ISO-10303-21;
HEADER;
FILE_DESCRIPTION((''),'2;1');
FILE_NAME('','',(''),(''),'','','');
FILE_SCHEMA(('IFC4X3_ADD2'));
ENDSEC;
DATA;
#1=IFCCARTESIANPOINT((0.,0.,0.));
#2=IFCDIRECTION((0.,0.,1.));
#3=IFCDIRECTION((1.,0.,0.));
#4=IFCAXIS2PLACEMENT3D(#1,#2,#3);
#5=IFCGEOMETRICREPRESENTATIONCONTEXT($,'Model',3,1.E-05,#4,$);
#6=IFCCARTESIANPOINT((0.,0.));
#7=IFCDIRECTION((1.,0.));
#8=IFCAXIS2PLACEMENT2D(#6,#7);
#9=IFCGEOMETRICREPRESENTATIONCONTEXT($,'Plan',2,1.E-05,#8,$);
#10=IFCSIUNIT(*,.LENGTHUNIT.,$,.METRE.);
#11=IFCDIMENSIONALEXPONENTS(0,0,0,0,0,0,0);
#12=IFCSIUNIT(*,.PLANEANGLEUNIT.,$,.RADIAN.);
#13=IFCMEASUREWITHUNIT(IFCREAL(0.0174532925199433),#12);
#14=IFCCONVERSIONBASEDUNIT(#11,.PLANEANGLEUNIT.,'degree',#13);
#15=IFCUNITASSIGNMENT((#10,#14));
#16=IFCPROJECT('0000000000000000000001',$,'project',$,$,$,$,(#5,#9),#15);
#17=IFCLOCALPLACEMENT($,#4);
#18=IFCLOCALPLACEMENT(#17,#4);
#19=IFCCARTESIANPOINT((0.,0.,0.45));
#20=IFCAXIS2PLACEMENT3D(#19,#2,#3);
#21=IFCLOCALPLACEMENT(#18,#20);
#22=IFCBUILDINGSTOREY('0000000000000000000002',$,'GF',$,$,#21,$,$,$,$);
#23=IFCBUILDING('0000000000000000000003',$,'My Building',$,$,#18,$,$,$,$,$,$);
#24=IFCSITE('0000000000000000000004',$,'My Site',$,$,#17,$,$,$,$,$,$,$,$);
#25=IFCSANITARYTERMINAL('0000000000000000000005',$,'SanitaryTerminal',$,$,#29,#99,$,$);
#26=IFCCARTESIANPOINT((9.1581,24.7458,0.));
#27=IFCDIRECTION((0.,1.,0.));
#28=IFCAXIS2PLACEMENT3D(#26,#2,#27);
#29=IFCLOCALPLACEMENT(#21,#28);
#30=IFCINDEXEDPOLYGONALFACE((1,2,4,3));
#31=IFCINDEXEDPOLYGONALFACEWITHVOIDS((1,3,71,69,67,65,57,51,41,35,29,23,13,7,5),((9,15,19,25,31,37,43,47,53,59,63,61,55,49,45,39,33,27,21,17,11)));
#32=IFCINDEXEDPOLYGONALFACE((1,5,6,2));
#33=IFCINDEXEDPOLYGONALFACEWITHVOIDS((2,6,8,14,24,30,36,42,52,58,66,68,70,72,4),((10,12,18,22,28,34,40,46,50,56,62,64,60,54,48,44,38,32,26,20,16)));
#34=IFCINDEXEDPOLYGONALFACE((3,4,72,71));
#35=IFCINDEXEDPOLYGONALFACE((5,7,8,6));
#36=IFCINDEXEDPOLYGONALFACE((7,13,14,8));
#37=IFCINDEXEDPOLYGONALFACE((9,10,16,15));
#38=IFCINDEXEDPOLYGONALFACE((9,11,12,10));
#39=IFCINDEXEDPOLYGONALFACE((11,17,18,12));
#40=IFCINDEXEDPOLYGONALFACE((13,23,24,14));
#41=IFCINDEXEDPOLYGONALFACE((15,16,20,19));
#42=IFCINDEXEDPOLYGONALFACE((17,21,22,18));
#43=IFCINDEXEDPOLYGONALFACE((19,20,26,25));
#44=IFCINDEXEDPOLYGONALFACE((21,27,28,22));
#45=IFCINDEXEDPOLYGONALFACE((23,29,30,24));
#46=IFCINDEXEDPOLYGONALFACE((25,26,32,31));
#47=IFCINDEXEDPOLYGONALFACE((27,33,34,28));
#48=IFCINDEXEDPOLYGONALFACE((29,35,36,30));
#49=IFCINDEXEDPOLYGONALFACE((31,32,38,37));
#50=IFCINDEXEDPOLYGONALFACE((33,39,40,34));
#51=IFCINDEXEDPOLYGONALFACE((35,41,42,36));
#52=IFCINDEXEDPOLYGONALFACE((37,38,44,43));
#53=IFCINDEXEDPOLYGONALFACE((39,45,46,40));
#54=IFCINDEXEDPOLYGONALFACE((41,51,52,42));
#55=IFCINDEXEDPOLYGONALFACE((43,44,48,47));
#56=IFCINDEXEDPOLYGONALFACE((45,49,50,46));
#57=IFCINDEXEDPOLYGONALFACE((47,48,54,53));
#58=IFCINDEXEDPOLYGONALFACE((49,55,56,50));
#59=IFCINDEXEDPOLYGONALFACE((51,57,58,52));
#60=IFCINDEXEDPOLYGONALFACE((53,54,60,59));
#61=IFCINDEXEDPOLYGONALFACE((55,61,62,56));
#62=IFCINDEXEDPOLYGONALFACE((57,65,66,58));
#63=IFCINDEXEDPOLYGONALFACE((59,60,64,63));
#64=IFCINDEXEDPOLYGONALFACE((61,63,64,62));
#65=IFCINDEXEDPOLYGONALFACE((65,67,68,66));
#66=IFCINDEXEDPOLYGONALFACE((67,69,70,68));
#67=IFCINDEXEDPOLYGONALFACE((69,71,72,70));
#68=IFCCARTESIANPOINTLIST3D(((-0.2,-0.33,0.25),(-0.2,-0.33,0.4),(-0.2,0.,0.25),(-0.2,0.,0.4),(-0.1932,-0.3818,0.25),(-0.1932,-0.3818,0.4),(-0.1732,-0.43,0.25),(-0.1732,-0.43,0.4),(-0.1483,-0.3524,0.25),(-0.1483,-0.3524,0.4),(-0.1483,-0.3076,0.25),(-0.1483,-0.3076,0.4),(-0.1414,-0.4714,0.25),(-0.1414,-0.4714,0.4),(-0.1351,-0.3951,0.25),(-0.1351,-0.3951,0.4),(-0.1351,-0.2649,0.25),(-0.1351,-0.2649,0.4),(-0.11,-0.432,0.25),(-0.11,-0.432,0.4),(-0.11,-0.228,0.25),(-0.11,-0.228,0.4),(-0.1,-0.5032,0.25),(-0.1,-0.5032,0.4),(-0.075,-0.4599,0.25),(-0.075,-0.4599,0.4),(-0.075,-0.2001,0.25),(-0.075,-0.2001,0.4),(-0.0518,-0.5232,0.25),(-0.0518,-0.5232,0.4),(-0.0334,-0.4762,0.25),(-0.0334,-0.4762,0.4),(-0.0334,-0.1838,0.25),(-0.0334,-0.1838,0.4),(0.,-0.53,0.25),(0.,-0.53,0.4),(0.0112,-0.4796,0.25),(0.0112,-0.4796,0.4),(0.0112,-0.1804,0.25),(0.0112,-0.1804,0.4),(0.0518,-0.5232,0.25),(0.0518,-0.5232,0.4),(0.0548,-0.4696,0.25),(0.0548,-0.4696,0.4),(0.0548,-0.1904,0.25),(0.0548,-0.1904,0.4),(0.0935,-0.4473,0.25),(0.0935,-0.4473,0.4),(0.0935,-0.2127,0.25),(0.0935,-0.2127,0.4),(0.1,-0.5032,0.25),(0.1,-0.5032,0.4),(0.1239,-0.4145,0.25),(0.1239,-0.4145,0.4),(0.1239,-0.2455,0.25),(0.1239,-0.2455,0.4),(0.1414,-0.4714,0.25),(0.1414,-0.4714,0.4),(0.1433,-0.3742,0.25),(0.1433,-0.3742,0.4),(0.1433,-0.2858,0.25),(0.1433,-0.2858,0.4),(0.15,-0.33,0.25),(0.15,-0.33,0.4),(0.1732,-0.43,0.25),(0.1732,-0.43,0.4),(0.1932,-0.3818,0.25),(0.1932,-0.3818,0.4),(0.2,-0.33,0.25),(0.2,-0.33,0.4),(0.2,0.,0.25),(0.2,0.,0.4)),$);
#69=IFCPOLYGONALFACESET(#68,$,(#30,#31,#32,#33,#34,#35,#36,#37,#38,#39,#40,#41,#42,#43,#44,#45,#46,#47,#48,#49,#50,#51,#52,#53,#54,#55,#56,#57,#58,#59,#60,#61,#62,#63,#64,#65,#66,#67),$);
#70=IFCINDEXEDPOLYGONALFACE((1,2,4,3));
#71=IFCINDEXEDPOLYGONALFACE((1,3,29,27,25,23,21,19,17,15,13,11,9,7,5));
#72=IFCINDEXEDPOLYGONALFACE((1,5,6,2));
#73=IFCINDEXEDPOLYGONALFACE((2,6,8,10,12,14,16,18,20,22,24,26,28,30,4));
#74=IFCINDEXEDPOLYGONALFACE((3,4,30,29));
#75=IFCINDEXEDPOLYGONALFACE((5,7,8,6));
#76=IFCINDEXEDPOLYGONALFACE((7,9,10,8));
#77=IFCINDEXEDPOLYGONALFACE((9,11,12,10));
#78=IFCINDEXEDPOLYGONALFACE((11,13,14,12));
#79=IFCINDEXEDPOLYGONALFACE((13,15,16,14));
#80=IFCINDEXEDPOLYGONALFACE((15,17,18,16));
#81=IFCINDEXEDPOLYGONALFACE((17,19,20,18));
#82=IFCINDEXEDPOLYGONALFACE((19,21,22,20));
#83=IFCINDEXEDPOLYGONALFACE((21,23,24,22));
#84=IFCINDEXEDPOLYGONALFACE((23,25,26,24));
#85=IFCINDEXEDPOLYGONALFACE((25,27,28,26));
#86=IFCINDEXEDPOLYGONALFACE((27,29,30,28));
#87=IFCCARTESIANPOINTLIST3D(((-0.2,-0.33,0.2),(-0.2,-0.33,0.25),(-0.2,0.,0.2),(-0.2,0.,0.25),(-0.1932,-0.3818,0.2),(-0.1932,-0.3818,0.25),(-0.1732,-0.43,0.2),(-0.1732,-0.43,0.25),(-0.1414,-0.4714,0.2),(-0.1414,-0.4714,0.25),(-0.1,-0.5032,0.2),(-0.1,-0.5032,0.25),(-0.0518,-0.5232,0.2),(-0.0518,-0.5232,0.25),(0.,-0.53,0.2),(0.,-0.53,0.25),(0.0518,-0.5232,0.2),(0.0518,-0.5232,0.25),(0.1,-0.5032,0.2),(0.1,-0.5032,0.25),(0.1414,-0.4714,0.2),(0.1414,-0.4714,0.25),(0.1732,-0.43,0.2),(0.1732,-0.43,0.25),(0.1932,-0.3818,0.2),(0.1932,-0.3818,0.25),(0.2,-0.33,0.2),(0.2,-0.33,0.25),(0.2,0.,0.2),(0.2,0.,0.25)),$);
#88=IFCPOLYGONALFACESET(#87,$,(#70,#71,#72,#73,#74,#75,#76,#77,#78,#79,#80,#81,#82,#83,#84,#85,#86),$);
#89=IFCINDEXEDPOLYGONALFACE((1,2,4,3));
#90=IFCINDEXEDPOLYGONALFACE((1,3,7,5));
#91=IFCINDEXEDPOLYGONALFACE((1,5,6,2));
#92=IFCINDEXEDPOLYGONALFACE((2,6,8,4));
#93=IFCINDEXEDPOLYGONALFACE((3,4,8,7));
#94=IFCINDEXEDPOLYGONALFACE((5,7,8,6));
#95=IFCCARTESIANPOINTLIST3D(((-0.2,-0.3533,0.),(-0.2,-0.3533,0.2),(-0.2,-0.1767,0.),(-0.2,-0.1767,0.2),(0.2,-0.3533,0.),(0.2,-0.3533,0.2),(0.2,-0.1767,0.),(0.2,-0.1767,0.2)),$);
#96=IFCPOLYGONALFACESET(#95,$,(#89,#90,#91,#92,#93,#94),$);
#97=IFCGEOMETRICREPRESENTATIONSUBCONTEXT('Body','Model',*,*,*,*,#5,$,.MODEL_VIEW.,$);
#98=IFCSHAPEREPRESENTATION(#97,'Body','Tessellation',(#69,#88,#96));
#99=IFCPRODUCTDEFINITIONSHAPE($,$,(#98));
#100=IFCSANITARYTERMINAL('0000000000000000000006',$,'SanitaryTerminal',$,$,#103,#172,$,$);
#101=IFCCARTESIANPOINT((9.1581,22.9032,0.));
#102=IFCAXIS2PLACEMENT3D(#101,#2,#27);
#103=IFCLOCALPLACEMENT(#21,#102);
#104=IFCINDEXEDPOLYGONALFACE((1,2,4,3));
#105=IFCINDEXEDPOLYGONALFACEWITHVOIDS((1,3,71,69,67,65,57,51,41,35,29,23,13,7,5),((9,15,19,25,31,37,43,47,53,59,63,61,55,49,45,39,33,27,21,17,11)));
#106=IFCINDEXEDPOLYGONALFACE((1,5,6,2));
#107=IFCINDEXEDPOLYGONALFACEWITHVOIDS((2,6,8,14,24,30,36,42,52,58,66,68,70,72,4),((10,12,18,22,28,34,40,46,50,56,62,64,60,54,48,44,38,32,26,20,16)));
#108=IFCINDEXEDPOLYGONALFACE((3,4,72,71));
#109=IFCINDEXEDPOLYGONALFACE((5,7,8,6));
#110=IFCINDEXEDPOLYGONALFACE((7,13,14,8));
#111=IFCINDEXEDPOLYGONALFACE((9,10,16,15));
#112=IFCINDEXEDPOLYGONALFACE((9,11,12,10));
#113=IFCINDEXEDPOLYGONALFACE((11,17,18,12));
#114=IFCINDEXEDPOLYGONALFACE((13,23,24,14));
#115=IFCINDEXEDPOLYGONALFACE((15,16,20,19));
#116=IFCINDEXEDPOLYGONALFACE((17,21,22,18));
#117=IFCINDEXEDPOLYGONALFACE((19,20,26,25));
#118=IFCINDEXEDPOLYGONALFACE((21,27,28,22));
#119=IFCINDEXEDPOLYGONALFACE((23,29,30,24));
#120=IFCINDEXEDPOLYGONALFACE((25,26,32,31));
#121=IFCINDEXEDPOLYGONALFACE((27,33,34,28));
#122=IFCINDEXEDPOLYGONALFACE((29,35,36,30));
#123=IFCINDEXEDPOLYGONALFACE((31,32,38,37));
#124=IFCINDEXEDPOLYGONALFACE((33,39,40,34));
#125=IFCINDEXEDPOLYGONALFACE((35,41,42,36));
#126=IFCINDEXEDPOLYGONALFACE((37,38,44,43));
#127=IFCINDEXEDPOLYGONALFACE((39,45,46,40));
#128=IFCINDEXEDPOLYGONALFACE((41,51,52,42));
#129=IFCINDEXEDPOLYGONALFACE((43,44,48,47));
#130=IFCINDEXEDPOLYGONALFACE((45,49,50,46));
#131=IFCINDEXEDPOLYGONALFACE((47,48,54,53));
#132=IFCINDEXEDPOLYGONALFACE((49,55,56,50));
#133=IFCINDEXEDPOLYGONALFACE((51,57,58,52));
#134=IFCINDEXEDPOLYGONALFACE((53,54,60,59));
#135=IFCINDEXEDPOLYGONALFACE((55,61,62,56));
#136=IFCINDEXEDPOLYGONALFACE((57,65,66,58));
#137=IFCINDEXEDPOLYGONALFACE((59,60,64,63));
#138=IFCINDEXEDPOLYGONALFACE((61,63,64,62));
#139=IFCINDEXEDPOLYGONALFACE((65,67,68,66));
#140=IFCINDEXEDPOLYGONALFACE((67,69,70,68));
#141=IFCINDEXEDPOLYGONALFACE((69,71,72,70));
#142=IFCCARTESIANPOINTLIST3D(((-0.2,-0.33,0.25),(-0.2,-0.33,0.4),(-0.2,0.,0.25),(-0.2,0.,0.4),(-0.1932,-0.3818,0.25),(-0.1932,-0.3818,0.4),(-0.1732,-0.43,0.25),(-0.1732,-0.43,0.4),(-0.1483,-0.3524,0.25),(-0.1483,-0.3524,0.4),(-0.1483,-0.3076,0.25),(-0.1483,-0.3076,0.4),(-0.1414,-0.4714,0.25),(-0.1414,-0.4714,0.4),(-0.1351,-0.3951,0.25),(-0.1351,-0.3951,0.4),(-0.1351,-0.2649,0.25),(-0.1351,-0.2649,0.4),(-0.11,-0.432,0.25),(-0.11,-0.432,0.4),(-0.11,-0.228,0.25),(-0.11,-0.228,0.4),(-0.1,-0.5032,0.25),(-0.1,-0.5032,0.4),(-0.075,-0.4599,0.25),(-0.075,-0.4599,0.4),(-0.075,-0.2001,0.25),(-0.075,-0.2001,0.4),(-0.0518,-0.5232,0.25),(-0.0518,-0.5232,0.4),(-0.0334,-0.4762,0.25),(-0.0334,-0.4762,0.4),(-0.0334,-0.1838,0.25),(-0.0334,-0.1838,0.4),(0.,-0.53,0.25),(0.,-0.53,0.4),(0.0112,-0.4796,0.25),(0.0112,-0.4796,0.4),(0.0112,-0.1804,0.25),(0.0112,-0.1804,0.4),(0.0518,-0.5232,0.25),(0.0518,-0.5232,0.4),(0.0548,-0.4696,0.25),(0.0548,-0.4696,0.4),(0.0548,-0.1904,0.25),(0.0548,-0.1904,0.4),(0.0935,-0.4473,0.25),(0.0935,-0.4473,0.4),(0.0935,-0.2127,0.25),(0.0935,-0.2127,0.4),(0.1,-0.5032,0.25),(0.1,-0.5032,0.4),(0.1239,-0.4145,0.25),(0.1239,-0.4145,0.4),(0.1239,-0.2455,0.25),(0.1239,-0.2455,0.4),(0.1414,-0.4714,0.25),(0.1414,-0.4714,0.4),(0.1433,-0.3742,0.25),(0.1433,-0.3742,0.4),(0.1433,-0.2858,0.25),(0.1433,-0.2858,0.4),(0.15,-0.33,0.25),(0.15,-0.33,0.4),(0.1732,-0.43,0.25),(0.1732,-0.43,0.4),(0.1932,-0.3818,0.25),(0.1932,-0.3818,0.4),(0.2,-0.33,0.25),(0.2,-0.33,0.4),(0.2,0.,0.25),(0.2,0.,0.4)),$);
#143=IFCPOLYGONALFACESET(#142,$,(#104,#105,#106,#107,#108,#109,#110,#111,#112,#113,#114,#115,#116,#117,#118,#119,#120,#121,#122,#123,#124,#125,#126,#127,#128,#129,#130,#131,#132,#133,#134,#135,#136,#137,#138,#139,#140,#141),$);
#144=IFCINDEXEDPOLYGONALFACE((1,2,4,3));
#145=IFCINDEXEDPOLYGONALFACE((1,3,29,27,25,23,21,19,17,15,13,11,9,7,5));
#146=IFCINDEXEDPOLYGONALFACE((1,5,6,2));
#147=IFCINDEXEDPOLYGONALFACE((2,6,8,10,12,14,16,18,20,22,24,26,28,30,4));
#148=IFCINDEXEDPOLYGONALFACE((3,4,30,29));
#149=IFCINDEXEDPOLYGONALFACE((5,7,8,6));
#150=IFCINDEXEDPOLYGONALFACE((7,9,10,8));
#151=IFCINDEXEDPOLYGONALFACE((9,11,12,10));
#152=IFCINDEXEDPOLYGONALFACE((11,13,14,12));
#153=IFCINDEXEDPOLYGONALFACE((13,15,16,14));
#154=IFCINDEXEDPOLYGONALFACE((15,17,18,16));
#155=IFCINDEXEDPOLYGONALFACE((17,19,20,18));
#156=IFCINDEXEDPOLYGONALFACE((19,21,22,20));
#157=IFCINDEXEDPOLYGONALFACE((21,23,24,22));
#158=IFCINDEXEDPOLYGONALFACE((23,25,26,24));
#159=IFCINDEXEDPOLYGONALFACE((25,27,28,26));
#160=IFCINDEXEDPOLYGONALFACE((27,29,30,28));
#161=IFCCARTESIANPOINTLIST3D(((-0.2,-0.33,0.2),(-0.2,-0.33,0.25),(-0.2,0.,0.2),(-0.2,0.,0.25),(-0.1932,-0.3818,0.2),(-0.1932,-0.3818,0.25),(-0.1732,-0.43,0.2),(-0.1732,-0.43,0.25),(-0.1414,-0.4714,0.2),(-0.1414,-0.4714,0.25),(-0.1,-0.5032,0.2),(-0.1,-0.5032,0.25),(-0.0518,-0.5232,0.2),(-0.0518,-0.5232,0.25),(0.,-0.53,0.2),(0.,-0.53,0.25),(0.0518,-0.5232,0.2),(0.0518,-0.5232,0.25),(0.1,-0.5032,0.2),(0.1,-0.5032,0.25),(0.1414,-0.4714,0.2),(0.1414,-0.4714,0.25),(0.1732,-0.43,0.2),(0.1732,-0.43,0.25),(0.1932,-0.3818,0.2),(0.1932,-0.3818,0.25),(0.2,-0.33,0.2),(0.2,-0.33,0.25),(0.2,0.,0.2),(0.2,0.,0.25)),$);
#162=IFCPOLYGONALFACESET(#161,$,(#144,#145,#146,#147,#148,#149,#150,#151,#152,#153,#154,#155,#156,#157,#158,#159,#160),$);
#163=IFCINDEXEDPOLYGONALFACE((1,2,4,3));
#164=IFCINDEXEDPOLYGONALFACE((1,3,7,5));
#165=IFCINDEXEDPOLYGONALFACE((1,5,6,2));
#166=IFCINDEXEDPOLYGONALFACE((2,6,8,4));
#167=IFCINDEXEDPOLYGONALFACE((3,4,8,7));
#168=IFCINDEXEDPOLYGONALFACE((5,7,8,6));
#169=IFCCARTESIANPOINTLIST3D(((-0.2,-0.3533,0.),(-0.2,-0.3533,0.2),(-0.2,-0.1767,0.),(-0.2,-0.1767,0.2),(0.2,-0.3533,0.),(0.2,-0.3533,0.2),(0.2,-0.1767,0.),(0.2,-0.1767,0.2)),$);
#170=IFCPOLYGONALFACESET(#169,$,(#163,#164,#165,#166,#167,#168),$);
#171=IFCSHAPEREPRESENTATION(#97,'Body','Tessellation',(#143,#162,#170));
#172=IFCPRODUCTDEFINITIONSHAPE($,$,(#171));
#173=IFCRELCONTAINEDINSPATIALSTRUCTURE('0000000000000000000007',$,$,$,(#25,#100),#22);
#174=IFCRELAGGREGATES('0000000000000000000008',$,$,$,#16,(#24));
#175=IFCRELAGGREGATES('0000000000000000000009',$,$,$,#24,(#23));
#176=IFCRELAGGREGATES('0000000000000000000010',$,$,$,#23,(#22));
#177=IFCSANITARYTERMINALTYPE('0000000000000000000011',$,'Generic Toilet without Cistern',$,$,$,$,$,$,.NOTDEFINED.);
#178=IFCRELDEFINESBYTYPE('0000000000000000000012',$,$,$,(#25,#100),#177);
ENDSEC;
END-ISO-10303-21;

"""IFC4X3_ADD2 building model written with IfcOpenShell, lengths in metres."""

from ifc_helpers import new_model, entity, si_unit, converted_unit, frame, frame_2d, origin_with_axes, origin_2d_with_axis, place, context, subcontext, project, spatial, line, arc, indexed_curve, circle_curve, outline, extrude, shape, source, transform, mapped, type_object, type_shapes, element, save


model = new_model("IFC4X3_ADD2")

# Units and contexts
model_context = context("Model", 3, precision=1e-05, world=origin_with_axes())
plan_context = context("Plan", 2, precision=1e-05, world=origin_2d_with_axis())
body_context_1 = subcontext(model_context, "Body", "Model", "MODEL_VIEW")
body_context_2 = subcontext(plan_context, "Body", "Plan", "PLAN_VIEW")
ifc_project = project(units=[si_unit("LENGTHUNIT", "METRE"), converted_unit("PLANEANGLEUNIT", "degree", entity("IfcReal", 0.0174532925199433), si_unit("PLANEANGLEUNIT", "RADIAN"), dimensions=[0, 0, 0, 0, 0, 0, 0])], contexts=[model_context, plan_context])

# Site, building, storey
site_placement = place(None, origin_with_axes())
site = spatial("IfcSite", under=ifc_project, at=site_placement, Name="My Site")
building_placement = place(site_placement, origin_with_axes())
building = spatial("IfcBuilding", under=site, at=building_placement, Name="My Building")
storey_placement = place(building_placement, frame((0.0, 0.0, 0.45), z_axis=(0.0, 0.0, 1.0), x_axis=(1.0, 0.0, 0.0)))
storey = spatial("IfcBuildingStorey", under=building, at=storey_placement, Name="GF")

# Sanitary terminals
sanitary_terminal_type_1 = type_object("IfcSanitaryTerminalType", Name="Generic Toilet without Cistern", PredefinedType="NOTDEFINED")
shared_shape_1 = source(origin_with_axes(), body_context_1, "Body", "SweptSolid", [
    extrude(outline(indexed_curve([(-0.2, 0.0), (0.2, 0.0), (0.2, -0.33), (0.1414, -0.4714), (0.0, -0.53), (-0.1414, -0.4714), (-0.2, -0.33)], segments=[line(1, 2), line(2, 3), arc(3, 4, 5), arc(5, 6, 7), line(7, 1)]), holes=[circle_curve(frame_2d((0.0, -0.33)), 0.15)]), frame((0.0, 0.0, 0.25), z_axis=(0.0, 0.0, 1.0), x_axis=(1.0, 0.0, 0.0)), (0.0, 0.0, 1.0), 0.15),
    extrude(outline(indexed_curve([(-0.2, 0.0), (0.2, 0.0), (0.2, -0.33), (0.1414, -0.4714), (0.0, -0.53), (-0.1414, -0.4714), (-0.2, -0.33)], segments=[line(1, 2), line(2, 3), arc(3, 4, 5), arc(5, 6, 7), line(7, 1)])), frame((0.0, 0.0, 0.2), z_axis=(0.0, 0.0, 1.0), x_axis=(1.0, 0.0, 0.0)), (0.0, 0.0, 1.0), 0.05),
    extrude(outline(indexed_curve([(-0.2, -0.1767), (0.2, -0.1767), (0.2, -0.3533), (-0.2, -0.3533)], segments=[line(1, 2, 3, 4, 1)])), origin_with_axes(), (0.0, 0.0, 1.0), 0.2),
])
shared_shape_2 = source(origin_with_axes(), body_context_2, "Body", "Annotation2D", [
    entity("IfcGeometricCurveSet", [entity("IfcIndexedPolyCurve", entity("IfcCartesianPointList2D", [[-0.1068, -0.124], [-0.0957, -0.1129], [-0.0804, -0.1088], [0.0804, -0.1088], [0.0957, -0.1129], [0.1068, -0.124], [0.1109, -0.1393], [0.1109, -0.3476], [0.1025, -0.3926], [0.0784, -0.4308], [0.0424, -0.4563], [0.0, -0.4652], [-0.0424, -0.4563], [-0.0784, -0.4308], [-0.1025, -0.3926], [-0.1109, -0.3476], [-0.1109, -0.1393]]), [entity("IfcLineIndex", [1, 2, 3, 4, 5, 6, 7, 8, 9, 10, 11, 12, 13, 14, 15, 16, 17, 1])]), entity("IfcIndexedPolyCurve", entity("IfcCartesianPointList2D", [[-0.1962, -0.2314], [-0.1848, -0.301], [-0.1764, -0.3339], [-0.1663, -0.3651], [-0.1546, -0.3944], [-0.1414, -0.4213], [-0.1269, -0.4458], [-0.1111, -0.4675], [-0.0943, -0.4862], [-0.0765, -0.5018], [-0.0581, -0.514], [-0.039, -0.5229], [-0.0196, -0.5282], [0.0, -0.53], [0.0196, -0.5282], [0.039, -0.5229], [0.0581, -0.514], [0.0765, -0.5018], [0.0943, -0.4862], [0.1111, -0.4675], [0.1269, -0.4458], [0.1414, -0.4213], [0.1546, -0.3944], [0.1663, -0.3651], [0.1764, -0.3339], [0.1848, -0.301], [0.1962, -0.2314], [0.2, -0.159], [0.1872, 0.0], [-0.1872, 0.0], [-0.2, -0.159]]), [entity("IfcLineIndex", [1, 2, 3, 4, 5, 6, 7, 8, 9, 10, 11, 12, 13, 14, 15, 16, 17, 18, 19, 20, 21, 22, 23, 24, 25, 26, 27, 28, 29, 30, 31, 1])])]),
])
type_shapes(sanitary_terminal_type_1, [shared_shape_1, shared_shape_2])
for number, where, z_axis, x_axis, name in (
    (1, (9.1581, 24.7458, 0.0), (0.0, 0.0, 1.0), (0.0, 1.0, 0.0), "SanitaryTerminal"),
    (2, (9.1581, 22.9032, 0.0), (0.0, 0.0, 1.0), (0.0, 1.0, 0.0), "SanitaryTerminal"),
):
    element("IfcSanitaryTerminal", number, at=place(storey_placement, frame(where, z_axis=z_axis, x_axis=x_axis)), inside=storey, type_object=sanitary_terminal_type_1, Name=name, shapes=[
        shape(body_context_1, "Body", "MappedRepresentation", [mapped(shared_shape_1, transform((0.0, 0.0, 0.0), x_axis=(1.0, 0.0, 0.0), y_axis=(0.0, 1.0, 0.0), z_axis=(0.0, 0.0, 1.0), scale=1.0))]),
        shape(body_context_2, "Body", "MappedRepresentation", [mapped(shared_shape_2, transform((0.0, 0.0, 0.0), x_axis=(1.0, 0.0, 0.0), y_axis=(0.0, 1.0, 0.0), z_axis=(0.0, 0.0, 1.0), scale=1.0))]),
    ])

save(model, "model.ifc")
